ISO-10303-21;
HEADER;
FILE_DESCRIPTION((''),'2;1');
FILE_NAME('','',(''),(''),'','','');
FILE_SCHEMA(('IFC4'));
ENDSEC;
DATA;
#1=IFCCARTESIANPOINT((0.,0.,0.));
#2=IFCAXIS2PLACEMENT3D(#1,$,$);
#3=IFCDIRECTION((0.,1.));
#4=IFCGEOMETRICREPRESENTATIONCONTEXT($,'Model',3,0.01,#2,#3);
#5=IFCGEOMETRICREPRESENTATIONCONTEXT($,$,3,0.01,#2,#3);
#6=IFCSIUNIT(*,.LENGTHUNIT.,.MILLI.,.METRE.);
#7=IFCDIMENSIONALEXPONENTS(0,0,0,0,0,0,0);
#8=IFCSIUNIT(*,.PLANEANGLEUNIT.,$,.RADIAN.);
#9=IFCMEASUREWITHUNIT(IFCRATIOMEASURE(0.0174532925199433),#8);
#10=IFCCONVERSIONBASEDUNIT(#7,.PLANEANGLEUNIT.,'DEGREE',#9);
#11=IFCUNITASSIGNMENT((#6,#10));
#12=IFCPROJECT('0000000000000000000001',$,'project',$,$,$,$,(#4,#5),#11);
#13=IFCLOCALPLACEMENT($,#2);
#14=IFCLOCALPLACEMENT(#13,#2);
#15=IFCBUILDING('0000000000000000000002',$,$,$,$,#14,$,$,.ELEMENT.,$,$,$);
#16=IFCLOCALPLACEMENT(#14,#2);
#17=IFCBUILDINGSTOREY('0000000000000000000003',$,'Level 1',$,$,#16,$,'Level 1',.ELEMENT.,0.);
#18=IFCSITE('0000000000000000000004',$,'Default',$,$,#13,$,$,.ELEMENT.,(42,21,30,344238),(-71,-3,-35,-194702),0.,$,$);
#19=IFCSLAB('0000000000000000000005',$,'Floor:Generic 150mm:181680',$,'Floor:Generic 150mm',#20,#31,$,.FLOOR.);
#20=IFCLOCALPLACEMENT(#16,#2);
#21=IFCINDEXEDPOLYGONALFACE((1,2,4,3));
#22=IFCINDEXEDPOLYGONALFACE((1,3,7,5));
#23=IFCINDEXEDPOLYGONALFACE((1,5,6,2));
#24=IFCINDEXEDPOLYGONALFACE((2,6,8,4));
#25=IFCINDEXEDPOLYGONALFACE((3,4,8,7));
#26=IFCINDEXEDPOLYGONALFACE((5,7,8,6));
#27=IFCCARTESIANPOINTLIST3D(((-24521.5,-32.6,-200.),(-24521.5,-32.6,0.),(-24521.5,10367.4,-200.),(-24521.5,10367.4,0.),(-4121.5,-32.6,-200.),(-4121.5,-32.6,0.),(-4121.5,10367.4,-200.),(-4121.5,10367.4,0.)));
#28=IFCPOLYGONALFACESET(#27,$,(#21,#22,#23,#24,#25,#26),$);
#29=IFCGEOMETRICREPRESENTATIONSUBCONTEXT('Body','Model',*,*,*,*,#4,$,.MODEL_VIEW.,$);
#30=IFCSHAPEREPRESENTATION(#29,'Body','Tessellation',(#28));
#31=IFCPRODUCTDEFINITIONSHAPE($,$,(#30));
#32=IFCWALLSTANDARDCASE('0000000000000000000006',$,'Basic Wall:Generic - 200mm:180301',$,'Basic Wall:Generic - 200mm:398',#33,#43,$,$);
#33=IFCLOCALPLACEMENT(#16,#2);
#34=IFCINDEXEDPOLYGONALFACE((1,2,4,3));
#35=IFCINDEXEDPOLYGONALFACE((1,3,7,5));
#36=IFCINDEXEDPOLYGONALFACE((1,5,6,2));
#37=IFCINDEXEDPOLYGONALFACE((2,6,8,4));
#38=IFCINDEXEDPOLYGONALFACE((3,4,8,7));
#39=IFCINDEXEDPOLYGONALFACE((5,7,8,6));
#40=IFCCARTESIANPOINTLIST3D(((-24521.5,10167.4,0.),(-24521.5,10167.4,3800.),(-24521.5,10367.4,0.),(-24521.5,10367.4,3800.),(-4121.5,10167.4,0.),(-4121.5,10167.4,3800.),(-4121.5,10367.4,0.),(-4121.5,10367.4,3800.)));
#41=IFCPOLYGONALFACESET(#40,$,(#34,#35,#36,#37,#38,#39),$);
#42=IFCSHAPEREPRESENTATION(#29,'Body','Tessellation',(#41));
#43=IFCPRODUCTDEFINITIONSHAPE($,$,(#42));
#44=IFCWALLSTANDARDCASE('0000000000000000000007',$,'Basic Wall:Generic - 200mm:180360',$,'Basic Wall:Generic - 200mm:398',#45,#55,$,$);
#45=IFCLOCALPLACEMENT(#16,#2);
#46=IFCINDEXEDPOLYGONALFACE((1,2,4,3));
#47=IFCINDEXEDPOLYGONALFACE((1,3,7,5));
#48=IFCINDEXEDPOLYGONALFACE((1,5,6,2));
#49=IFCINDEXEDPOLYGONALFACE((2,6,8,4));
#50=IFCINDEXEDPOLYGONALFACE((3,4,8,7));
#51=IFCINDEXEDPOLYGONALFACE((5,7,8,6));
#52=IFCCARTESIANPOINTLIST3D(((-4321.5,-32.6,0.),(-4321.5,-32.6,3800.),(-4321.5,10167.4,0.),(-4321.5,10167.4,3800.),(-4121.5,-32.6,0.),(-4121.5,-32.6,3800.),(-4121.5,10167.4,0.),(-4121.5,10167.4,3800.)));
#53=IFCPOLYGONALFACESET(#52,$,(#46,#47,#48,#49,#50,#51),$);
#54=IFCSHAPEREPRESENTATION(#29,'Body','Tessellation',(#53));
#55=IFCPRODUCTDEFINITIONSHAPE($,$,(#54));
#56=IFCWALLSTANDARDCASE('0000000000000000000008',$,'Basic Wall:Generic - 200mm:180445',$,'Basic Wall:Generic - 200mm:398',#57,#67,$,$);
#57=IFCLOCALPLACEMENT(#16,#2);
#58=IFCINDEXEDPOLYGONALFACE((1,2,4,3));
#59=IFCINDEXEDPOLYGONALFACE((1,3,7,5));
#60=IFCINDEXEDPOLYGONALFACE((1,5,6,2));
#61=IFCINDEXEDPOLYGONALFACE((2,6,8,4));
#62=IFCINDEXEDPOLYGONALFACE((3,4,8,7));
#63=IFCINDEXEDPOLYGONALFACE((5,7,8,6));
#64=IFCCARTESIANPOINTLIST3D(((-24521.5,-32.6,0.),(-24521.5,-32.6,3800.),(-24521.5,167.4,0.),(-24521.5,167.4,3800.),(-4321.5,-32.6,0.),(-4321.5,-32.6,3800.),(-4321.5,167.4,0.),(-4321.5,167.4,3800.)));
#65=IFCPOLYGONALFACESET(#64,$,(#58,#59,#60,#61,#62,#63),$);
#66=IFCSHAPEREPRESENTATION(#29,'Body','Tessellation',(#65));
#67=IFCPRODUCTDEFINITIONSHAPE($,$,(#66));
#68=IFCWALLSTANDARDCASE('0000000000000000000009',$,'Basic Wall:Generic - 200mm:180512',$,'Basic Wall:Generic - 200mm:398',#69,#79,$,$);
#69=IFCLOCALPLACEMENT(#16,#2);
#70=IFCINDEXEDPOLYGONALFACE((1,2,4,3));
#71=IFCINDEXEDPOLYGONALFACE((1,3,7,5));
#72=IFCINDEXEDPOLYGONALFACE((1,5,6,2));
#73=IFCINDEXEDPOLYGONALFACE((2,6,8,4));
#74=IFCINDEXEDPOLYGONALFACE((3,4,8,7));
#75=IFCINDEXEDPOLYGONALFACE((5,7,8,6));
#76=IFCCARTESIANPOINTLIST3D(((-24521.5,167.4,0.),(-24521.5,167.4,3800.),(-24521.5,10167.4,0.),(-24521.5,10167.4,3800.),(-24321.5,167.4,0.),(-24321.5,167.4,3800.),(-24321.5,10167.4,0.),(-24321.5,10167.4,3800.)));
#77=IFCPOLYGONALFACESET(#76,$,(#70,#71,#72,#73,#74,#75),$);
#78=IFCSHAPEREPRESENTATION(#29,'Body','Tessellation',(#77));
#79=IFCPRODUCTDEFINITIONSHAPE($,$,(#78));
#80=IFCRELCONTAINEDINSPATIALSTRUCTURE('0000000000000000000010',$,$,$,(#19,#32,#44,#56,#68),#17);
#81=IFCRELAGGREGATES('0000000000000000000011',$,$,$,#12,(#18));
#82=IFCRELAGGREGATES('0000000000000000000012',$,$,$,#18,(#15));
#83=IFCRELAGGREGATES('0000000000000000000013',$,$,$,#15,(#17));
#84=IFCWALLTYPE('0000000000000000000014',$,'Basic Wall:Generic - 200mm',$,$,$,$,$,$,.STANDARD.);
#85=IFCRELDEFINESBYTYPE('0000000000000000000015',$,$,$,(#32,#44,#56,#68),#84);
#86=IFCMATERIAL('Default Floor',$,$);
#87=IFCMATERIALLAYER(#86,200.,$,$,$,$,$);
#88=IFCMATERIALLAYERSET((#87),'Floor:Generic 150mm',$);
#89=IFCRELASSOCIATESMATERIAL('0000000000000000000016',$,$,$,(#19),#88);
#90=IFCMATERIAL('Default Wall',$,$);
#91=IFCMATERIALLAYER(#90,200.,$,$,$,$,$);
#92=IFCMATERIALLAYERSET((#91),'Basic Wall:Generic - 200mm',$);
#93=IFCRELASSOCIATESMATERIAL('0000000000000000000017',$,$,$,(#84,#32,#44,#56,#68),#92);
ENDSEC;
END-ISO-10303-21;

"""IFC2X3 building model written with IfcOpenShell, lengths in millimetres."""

from ifc_helpers import new_model, entity, si_unit, converted_unit, direction, frame, frame_2d, origin, origin_2d_with_axis, place, context, subcontext, project, spatial, rectangle, extrude, material, layer, layer_set, layer_usage, type_object, element, save


model = new_model("IFC2X3")

# Units and contexts
model_context = context("Model", 3, precision=0.01, world=origin(), true_north=direction((0.0, 1.0)))
context_of_model = context(None, 3, precision=0.01, world=origin(), true_north=direction((0.0, 1.0)))
body_context = subcontext(model_context, "Body", "Model", "MODEL_VIEW")
ifc_project = project(units=[si_unit("LENGTHUNIT", "METRE", prefix="MILLI"), converted_unit("PLANEANGLEUNIT", "DEGREE", entity("IfcRatioMeasure", 0.0174532925199433), si_unit("PLANEANGLEUNIT", "RADIAN"), dimensions=[0, 0, 0, 0, 0, 0, 0])], contexts=[model_context, context_of_model])

# Site, building, storey
site_placement = place(None, origin())
site = spatial("IfcSite", under=ifc_project, at=site_placement, Name="Default", CompositionType="ELEMENT", RefLatitude=(42, 21, 30, 344238), RefLongitude=(-71, -3, -35, -194702), RefElevation=0.0)
building_placement = place(site_placement, origin())
building = spatial("IfcBuilding", under=site, at=building_placement, CompositionType="ELEMENT")
storey_placement = place(building_placement, origin())
storey = spatial("IfcBuildingStorey", under=building, at=storey_placement, Name="Level 1", LongName="Level 1", CompositionType="ELEMENT", Elevation=0.0)

# Slab
ifc_material_1 = material(Name="Default Floor")
ifc_layer_1 = layer(ifc_material_1, 200.0)
ifc_layer_set_1 = layer_set([ifc_layer_1], Name="Floor:Generic 150mm")
ifc_layer_usage_1 = layer_usage(ifc_layer_set_1, "AXIS3", "POSITIVE", 0.0)
slab_placement = place(storey_placement, origin())
element("IfcSlab", 1, at=slab_placement, inside=storey, material=ifc_layer_usage_1, Name="Floor:Generic 150mm:181680", ObjectType="Floor:Generic 150mm", PredefinedType="FLOOR", context=body_context, shape_type="SweptSolid", body=[
    extrude(rectangle(XDim=10400.0, YDim=20400.0, at=origin_2d_with_axis()), frame((-14321.5, 5167.4, 0.0), z_axis=(0.0, 0.0, -1.0), x_axis=(0.0, 1.0, 0.0)), (0.0, 0.0, 1.0), 200.0),
])

# Walls
ifc_material_2 = material(Name="Default Wall")
ifc_layer_2 = layer(ifc_material_2, 200.0)
ifc_layer_set_2 = layer_set([ifc_layer_2], Name="Basic Wall:Generic - 200mm")
ifc_layer_usage_2 = layer_usage(ifc_layer_set_2, "AXIS2", "NEGATIVE", 100.0)
wall_type = type_object("IfcWallType", Name="Basic Wall:Generic - 200mm", PredefinedType="STANDARD", material=ifc_layer_set_2)
wall_1_placement = place(storey_placement, frame((-24521.5, 10267.4, 0.0)))
element("IfcWallStandardCase", 2, at=wall_1_placement, inside=storey, type_object=wall_type, material=ifc_layer_usage_2, Name="Basic Wall:Generic - 200mm:180301", ObjectType="Basic Wall:Generic - 200mm:398", context=body_context, shape_type="SweptSolid", body=[
    extrude(rectangle(XDim=20400.0, YDim=200.0, at=frame_2d((10200.0, 0.0), x_axis=(-1.0, 0.0))), origin(), (0.0, 0.0, 1.0), 3800.0),
])
ifc_layer_usage_3 = layer_usage(ifc_layer_set_2, "AXIS2", "NEGATIVE", 100.0)
wall_2_placement = place(storey_placement, frame((-4221.5, 10167.4, 0.0), z_axis=(0.0, 0.0, 1.0), x_axis=(0.0, -1.0, 0.0)))
element("IfcWallStandardCase", 3, at=wall_2_placement, inside=storey, type_object=wall_type, material=ifc_layer_usage_3, Name="Basic Wall:Generic - 200mm:180360", ObjectType="Basic Wall:Generic - 200mm:398", context=body_context, shape_type="SweptSolid", body=[
    extrude(rectangle(XDim=10200.0, YDim=200.0, at=frame_2d((5100.0, 0.0), x_axis=(-1.0, 0.0))), origin(), (0.0, 0.0, 1.0), 3800.0),
])
ifc_layer_usage_4 = layer_usage(ifc_layer_set_2, "AXIS2", "NEGATIVE", 100.0)
wall_3_placement = place(storey_placement, frame((-4321.5, 67.4, 0.0), z_axis=(0.0, 0.0, 1.0), x_axis=(-1.0, 0.0, 0.0)))
element("IfcWallStandardCase", 4, at=wall_3_placement, inside=storey, type_object=wall_type, material=ifc_layer_usage_4, Name="Basic Wall:Generic - 200mm:180445", ObjectType="Basic Wall:Generic - 200mm:398", context=body_context, shape_type="SweptSolid", body=[
    extrude(rectangle(XDim=20200.0, YDim=200.0, at=frame_2d((10100.0, 0.0), x_axis=(-1.0, 0.0))), origin(), (0.0, 0.0, 1.0), 3800.0),
])
ifc_layer_usage_5 = layer_usage(ifc_layer_set_2, "AXIS2", "NEGATIVE", 100.0)
wall_4_placement = place(storey_placement, frame((-24421.5, 167.4, 0.0), z_axis=(0.0, 0.0, 1.0), x_axis=(0.0, 1.0, 0.0)))
element("IfcWallStandardCase", 5, at=wall_4_placement, inside=storey, type_object=wall_type, material=ifc_layer_usage_5, Name="Basic Wall:Generic - 200mm:180512", ObjectType="Basic Wall:Generic - 200mm:398", context=body_context, shape_type="SweptSolid", body=[
    extrude(rectangle(XDim=10000.0, YDim=200.0, at=frame_2d((5000.0, 0.0), x_axis=(-1.0, 0.0))), origin(), (0.0, 0.0, 1.0), 3800.0),
])

save(model, "model.ifc")
